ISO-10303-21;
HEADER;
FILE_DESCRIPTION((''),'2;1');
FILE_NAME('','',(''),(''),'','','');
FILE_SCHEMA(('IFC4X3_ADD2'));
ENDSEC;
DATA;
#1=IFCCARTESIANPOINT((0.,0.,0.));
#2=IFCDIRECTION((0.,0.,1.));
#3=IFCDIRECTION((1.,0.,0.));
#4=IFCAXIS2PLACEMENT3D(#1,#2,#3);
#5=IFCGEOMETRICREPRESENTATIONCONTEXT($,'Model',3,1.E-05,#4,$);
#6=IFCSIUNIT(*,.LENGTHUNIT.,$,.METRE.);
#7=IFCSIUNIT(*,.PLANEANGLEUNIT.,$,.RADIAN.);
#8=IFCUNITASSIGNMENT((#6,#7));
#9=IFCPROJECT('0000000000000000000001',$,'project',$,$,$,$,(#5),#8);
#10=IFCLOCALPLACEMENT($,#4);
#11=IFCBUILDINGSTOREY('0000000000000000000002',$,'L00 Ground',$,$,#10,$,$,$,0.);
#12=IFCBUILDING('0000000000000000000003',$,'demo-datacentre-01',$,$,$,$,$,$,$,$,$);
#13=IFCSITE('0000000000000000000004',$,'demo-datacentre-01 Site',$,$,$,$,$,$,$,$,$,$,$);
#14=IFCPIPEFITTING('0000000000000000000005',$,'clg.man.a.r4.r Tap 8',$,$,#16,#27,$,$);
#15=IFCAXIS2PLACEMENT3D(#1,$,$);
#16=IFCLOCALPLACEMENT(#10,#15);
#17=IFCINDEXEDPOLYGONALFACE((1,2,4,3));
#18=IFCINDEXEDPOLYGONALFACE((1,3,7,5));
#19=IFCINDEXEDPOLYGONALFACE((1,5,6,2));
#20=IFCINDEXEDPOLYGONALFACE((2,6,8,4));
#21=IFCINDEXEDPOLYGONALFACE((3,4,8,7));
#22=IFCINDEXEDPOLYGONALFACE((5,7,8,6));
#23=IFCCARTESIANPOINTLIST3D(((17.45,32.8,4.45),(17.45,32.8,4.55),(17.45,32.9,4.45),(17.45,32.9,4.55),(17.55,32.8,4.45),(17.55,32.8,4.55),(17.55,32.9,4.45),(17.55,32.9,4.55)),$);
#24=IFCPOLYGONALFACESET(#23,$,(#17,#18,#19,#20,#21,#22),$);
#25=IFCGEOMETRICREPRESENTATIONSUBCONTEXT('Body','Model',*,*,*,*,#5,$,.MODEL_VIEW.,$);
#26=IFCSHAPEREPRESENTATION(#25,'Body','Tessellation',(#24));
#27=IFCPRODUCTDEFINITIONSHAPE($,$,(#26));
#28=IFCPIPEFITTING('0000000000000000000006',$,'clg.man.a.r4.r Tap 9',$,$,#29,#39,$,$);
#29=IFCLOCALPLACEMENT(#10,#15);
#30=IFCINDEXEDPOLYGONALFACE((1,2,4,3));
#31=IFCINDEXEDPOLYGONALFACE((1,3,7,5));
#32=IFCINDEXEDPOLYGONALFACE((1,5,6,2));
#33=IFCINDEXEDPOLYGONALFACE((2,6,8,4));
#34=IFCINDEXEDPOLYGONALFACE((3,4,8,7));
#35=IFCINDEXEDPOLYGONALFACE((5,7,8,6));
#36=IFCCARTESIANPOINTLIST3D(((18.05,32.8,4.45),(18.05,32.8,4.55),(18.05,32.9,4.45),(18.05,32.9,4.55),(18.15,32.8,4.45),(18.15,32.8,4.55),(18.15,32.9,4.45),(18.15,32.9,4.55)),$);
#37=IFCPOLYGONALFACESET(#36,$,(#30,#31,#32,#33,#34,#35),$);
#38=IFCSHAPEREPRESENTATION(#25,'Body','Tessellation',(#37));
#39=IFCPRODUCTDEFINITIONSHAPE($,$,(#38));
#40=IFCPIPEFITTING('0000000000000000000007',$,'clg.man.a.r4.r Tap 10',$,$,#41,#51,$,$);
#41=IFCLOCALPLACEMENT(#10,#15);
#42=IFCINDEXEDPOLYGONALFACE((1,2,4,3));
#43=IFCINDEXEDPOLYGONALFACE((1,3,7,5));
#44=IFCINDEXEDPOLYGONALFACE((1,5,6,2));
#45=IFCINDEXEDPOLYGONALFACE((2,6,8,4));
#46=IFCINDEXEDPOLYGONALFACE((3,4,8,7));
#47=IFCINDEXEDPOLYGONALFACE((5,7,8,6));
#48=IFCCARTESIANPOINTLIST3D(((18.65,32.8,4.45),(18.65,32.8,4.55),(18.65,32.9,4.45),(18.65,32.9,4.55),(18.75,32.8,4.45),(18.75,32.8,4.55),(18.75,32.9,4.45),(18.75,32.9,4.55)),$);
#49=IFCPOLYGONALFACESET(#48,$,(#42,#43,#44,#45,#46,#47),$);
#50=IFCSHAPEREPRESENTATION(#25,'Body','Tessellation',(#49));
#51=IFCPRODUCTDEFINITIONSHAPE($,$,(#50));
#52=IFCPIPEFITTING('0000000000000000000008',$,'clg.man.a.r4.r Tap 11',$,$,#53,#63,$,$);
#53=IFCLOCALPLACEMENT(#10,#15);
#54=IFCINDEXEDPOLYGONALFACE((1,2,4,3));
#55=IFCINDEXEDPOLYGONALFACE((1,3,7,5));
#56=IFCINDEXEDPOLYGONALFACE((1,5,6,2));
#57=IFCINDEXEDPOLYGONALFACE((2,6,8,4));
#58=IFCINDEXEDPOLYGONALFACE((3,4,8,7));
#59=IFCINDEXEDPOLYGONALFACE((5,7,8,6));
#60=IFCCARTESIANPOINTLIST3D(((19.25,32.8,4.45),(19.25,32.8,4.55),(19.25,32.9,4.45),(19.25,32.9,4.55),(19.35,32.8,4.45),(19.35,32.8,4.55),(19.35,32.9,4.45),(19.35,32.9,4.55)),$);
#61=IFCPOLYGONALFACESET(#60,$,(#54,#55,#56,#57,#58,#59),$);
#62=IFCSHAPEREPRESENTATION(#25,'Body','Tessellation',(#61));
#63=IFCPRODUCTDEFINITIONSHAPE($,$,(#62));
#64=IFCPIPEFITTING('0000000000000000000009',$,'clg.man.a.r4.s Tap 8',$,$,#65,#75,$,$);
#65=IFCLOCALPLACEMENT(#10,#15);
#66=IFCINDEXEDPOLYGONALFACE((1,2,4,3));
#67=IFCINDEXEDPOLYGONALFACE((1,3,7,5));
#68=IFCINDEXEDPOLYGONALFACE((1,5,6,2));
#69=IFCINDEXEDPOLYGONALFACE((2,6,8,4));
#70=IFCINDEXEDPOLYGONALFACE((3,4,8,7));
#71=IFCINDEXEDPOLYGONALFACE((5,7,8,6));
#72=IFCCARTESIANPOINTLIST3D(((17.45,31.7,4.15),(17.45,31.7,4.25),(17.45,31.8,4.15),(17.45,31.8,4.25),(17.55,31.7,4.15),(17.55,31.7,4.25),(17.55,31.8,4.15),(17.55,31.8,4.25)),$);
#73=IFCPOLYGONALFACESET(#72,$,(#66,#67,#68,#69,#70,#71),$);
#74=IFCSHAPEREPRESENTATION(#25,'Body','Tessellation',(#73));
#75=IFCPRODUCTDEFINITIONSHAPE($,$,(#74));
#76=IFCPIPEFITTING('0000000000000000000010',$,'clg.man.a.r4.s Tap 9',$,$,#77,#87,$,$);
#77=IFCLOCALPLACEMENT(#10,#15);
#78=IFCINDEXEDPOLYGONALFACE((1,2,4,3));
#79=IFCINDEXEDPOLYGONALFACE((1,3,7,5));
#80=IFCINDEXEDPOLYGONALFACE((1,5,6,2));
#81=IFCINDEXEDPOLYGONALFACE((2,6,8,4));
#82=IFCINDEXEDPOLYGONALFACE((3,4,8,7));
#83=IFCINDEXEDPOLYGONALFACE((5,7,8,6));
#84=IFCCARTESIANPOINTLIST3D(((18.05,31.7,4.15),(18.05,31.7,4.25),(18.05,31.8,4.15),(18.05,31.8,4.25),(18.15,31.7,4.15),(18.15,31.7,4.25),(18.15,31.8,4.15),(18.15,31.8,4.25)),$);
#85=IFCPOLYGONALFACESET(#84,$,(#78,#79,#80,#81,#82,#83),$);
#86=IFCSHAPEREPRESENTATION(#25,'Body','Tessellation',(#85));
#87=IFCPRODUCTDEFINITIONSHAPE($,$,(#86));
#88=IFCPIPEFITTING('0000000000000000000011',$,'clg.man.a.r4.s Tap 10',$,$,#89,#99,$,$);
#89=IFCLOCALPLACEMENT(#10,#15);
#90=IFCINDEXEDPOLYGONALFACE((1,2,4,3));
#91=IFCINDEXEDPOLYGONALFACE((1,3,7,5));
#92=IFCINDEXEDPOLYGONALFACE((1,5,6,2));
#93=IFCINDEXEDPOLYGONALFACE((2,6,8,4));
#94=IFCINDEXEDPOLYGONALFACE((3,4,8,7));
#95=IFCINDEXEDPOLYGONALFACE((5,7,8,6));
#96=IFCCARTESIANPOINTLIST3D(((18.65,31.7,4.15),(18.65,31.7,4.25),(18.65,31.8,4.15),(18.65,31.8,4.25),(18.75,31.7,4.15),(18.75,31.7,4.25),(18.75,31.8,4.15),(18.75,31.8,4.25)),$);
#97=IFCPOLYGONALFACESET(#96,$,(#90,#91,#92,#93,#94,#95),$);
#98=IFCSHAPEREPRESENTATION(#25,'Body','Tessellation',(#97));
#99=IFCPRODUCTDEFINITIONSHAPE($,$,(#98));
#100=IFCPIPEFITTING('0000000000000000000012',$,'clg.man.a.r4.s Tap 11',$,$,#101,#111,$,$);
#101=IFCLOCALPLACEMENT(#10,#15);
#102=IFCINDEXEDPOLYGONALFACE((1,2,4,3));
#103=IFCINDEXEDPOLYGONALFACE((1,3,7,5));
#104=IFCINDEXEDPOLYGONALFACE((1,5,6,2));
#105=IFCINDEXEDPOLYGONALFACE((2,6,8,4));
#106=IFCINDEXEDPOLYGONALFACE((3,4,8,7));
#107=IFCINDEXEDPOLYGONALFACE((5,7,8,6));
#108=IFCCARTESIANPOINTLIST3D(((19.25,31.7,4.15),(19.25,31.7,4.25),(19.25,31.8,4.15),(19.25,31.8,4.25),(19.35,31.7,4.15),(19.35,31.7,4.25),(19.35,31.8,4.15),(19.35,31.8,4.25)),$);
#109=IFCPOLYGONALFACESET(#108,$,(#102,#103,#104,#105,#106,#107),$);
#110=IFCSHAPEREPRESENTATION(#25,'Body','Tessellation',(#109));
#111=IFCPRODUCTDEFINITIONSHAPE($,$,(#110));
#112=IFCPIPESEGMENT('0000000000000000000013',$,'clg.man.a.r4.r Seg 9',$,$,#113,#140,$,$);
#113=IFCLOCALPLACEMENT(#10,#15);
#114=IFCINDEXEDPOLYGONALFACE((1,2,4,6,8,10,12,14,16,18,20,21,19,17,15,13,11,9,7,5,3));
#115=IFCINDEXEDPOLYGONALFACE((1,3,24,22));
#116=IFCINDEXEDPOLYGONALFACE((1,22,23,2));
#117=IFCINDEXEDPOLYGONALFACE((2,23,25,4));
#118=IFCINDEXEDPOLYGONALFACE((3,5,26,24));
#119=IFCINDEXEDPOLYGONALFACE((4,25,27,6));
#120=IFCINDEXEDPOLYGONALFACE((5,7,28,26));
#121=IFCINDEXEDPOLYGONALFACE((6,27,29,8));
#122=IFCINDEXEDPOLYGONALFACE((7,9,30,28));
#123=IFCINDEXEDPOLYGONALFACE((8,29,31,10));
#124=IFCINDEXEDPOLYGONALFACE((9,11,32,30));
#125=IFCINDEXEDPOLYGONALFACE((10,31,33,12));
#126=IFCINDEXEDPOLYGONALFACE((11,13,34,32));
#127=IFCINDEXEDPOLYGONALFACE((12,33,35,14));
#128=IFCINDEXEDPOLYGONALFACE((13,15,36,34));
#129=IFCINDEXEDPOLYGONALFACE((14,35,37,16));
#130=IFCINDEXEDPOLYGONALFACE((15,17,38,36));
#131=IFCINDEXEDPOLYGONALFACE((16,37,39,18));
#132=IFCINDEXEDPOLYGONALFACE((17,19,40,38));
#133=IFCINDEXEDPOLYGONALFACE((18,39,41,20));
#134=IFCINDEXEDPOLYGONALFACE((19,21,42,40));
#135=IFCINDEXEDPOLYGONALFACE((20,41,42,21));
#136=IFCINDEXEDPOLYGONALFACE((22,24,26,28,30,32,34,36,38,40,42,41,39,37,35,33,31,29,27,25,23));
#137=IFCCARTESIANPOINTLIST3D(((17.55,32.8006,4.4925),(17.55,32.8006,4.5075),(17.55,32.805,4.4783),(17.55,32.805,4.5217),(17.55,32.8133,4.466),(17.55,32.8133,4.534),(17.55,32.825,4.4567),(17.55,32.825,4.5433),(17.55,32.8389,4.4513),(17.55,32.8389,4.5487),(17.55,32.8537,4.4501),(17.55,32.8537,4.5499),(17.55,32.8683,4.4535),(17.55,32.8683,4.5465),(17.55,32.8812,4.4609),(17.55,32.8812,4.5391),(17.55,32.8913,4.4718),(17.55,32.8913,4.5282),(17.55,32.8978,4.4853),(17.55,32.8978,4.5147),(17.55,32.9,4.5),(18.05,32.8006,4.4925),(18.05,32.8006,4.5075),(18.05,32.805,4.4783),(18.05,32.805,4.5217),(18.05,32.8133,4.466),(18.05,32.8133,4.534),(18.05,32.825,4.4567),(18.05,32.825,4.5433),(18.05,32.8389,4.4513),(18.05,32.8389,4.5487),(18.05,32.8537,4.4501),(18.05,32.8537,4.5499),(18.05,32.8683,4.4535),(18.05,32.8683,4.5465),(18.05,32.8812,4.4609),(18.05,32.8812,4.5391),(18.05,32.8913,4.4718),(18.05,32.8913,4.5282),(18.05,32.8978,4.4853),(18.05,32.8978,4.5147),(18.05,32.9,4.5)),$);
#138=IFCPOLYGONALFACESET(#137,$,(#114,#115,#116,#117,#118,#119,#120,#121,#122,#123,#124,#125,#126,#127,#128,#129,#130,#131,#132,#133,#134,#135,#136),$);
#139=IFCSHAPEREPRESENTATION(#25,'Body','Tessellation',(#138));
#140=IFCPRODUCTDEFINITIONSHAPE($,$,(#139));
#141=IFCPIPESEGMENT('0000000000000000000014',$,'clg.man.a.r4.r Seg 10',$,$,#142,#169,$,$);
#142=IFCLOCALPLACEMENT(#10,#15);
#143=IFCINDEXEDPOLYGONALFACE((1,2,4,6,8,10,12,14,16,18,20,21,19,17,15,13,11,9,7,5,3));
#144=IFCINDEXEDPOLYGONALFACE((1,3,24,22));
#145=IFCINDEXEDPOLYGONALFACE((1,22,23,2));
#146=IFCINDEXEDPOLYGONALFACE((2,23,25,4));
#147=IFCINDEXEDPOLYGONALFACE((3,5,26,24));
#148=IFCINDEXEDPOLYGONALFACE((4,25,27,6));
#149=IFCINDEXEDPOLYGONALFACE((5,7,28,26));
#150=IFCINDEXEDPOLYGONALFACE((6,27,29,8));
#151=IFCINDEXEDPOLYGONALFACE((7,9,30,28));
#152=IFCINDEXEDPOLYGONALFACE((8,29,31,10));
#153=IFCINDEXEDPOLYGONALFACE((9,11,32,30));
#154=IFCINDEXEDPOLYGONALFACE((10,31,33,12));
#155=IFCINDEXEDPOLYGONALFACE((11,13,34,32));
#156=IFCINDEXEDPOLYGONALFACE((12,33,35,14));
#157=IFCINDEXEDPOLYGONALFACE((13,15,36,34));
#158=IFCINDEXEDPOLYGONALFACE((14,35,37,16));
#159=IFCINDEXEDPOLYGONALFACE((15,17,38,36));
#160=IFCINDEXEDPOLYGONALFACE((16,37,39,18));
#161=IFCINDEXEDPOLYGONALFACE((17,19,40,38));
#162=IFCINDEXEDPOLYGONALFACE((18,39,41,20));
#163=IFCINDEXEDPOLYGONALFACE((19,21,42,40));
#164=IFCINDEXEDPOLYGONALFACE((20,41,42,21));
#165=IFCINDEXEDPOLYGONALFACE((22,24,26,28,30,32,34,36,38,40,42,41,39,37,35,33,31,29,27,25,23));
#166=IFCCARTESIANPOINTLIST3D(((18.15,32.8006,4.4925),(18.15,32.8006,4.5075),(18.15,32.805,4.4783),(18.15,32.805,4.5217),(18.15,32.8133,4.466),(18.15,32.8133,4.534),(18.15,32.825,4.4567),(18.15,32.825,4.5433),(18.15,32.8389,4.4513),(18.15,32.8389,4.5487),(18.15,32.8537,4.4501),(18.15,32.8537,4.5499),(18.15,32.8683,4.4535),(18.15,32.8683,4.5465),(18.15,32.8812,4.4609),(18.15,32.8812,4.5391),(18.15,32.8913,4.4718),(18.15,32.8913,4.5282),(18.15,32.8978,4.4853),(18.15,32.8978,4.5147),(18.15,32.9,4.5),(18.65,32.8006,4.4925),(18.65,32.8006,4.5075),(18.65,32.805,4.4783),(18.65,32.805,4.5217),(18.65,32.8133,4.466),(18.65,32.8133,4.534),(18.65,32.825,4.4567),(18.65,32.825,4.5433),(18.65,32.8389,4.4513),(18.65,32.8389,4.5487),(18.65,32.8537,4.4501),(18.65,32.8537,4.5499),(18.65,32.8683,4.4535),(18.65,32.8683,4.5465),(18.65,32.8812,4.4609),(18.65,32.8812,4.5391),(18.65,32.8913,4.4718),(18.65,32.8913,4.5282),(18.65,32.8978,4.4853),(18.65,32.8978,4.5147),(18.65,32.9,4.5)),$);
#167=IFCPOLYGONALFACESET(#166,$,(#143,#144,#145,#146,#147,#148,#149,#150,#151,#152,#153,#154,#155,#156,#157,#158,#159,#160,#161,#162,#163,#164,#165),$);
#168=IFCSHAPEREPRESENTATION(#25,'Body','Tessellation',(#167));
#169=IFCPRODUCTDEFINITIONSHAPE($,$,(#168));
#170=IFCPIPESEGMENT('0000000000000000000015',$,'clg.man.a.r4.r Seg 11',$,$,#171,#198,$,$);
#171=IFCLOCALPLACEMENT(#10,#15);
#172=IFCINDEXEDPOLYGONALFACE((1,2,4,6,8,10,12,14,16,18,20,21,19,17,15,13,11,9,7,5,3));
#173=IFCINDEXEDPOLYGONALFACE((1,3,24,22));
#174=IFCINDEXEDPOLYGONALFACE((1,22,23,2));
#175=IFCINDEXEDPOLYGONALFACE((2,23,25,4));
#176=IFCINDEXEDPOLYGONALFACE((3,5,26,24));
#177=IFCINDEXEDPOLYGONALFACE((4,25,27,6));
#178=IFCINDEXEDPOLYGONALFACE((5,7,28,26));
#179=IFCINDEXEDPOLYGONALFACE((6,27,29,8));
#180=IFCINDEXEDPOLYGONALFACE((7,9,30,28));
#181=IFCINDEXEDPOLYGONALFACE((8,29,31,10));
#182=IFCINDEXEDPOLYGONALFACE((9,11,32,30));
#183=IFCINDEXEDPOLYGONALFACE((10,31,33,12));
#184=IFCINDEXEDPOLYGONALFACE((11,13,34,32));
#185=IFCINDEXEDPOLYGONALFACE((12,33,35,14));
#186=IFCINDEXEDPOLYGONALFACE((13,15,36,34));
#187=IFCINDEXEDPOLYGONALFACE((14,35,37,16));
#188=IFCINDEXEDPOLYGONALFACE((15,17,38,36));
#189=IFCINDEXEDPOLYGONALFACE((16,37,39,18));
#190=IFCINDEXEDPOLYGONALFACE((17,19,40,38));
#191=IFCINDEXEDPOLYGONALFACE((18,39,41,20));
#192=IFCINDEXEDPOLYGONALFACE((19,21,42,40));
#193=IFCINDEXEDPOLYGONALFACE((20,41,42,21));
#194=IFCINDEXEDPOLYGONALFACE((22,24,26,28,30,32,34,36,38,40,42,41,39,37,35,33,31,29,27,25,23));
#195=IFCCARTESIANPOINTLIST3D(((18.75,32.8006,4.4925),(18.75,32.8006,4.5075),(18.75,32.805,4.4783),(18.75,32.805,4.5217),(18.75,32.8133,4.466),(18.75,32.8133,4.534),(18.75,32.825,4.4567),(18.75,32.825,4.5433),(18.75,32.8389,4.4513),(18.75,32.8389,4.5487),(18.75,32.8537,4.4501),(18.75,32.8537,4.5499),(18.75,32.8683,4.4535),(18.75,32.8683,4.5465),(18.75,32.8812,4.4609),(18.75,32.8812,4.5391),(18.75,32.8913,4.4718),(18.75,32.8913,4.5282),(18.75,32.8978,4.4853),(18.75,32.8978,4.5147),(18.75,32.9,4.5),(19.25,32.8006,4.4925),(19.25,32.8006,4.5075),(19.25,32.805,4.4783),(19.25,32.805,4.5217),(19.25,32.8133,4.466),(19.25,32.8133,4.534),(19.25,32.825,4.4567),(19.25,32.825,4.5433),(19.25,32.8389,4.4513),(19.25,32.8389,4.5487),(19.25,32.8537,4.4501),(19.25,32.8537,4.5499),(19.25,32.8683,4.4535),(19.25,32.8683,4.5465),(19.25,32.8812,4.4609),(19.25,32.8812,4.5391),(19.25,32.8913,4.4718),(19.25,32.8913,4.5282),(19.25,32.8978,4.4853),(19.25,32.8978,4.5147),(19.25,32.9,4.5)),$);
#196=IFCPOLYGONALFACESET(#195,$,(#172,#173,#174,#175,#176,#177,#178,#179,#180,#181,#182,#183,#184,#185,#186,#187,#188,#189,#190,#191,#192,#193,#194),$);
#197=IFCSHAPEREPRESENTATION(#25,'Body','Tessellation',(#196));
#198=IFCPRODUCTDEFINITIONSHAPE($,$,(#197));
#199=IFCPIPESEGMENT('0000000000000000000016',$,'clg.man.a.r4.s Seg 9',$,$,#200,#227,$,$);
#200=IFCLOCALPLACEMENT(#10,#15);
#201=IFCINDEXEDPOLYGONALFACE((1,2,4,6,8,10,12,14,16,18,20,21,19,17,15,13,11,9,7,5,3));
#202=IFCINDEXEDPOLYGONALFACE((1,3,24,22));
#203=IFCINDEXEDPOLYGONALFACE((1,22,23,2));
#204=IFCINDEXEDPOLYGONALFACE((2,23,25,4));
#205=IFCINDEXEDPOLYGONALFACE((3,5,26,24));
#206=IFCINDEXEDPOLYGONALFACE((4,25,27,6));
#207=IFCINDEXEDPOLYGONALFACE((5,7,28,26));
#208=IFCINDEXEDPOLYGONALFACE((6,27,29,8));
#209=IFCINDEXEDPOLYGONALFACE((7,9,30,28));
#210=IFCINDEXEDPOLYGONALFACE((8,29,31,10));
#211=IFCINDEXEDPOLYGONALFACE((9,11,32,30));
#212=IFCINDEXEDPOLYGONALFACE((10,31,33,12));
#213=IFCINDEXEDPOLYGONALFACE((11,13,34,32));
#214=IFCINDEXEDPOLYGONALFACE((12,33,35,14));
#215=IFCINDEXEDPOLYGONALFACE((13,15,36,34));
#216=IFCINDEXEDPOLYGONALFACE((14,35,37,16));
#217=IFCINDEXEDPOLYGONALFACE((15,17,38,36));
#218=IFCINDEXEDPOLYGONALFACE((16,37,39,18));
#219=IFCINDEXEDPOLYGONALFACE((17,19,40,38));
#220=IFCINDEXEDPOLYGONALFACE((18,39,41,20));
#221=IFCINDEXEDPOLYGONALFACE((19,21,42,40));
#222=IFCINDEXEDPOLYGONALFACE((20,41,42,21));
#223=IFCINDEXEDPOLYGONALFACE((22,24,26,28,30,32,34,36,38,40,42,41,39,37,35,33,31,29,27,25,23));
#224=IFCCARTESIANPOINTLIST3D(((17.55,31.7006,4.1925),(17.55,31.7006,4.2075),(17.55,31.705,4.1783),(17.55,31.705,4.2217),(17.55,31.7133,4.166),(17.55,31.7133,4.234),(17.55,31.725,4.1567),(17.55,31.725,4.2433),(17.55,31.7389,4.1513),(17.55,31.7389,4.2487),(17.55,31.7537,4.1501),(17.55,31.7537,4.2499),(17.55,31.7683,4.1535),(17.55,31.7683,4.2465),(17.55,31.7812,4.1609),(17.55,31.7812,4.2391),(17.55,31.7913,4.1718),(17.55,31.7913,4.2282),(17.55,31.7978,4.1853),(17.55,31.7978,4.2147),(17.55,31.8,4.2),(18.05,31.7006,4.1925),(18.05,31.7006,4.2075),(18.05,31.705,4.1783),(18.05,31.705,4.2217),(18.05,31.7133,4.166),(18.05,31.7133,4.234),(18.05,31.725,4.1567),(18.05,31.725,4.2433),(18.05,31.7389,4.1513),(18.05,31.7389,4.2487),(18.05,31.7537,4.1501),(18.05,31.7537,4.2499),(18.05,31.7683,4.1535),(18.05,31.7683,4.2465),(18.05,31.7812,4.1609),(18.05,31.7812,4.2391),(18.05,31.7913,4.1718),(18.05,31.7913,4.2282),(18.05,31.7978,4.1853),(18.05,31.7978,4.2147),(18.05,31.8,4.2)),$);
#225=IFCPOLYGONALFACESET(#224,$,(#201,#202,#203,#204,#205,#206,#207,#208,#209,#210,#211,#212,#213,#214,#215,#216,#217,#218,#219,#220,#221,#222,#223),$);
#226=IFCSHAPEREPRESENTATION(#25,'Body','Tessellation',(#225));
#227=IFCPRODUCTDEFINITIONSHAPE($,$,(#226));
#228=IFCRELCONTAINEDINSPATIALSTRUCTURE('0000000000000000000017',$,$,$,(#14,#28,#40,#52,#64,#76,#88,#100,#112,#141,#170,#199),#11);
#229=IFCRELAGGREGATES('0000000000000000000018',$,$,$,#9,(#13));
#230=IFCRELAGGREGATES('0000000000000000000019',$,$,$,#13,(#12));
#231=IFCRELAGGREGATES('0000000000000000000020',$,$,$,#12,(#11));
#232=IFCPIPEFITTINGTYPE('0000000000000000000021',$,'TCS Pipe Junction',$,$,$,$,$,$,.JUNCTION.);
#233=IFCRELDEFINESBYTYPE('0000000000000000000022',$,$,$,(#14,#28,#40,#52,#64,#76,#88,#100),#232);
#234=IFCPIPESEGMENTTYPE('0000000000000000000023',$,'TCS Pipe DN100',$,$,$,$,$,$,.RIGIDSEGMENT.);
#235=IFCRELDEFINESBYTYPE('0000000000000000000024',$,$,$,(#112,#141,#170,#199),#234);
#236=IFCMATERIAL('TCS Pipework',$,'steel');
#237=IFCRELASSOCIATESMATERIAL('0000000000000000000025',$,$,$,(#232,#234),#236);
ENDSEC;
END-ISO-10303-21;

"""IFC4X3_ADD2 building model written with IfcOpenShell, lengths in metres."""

from ifc_helpers import new_model, si_unit, frame, origin_with_axes, place, context, subcontext, project, spatial, rectangle, circle, extrude, material, type_object, element, save


model = new_model("IFC4X3_ADD2")

# Units and contexts
model_context = context("Model", 3, precision=1e-05, world=origin_with_axes())
body_context = subcontext(model_context, "Body", "Model", "MODEL_VIEW")
ifc_project = project(units=[si_unit("LENGTHUNIT", "METRE"), si_unit("PLANEANGLEUNIT", "RADIAN")], contexts=[model_context])

# Site, building, storey
site = spatial("IfcSite", under=ifc_project, Name="demo-datacentre-01 Site")
building = spatial("IfcBuilding", under=site, Name="demo-datacentre-01")
storey_placement = place(None, origin_with_axes())
storey = spatial("IfcBuildingStorey", under=building, at=storey_placement, Name="L00 Ground", Elevation=0.0)

# Pipe fittings
ifc_material = material(Name="TCS Pipework", Category="steel")
pipe_fitting_type = type_object("IfcPipeFittingType", Name="TCS Pipe Junction", PredefinedType="JUNCTION", material=ifc_material)
for number, where, z_axis, x_axis, name in (
    (1, (17.5, 32.85, 4.45), (0.0, 0.0, 1.0), (1.0, 0.0, 0.0), "clg.man.a.r4.r Tap 8"),
    (2, (18.1, 32.85, 4.45), (0.0, 0.0, 1.0), (1.0, 0.0, 0.0), "clg.man.a.r4.r Tap 9"),
    (3, (18.7, 32.85, 4.45), (0.0, 0.0, 1.0), (1.0, 0.0, 0.0), "clg.man.a.r4.r Tap 10"),
    (4, (19.3, 32.85, 4.45), (0.0, 0.0, 1.0), (1.0, 0.0, 0.0), "clg.man.a.r4.r Tap 11"),
    (5, (17.5, 31.75, 4.15), (0.0, 0.0, 1.0), (1.0, 0.0, 0.0), "clg.man.a.r4.s Tap 8"),
    (6, (18.1, 31.75, 4.15), (0.0, 0.0, 1.0), (1.0, 0.0, 0.0), "clg.man.a.r4.s Tap 9"),
    (7, (18.7, 31.75, 4.15), (0.0, 0.0, 1.0), (1.0, 0.0, 0.0), "clg.man.a.r4.s Tap 10"),
    (8, (19.3, 31.75, 4.15), (0.0, 0.0, 1.0), (1.0, 0.0, 0.0), "clg.man.a.r4.s Tap 11"),
):
    element("IfcPipeFitting", number, at=place(storey_placement, frame(where, z_axis=z_axis, x_axis=x_axis)), inside=storey, type_object=pipe_fitting_type, Name=name, context=body_context, shape_type="SweptSolid", body=[
        extrude(rectangle(XDim=0.1, YDim=0.1), origin_with_axes(), (0.0, 0.0, 1.0), 0.1),
    ])

# Pipe segments
pipe_segment_type_1 = type_object("IfcPipeSegmentType", Name="TCS Pipe DN100", PredefinedType="RIGIDSEGMENT", material=ifc_material)
pipe_segment_1_placement = place(storey_placement, frame((17.55, 32.85, 4.5), z_axis=(1.0, 0.0, 0.0), x_axis=(0.0, 1.0, 0.0)))
element("IfcPipeSegment", 9, at=pipe_segment_1_placement, inside=storey, type_object=pipe_segment_type_1, Name="clg.man.a.r4.r Seg 9", context=body_context, shape_type="SweptSolid", body=[
    extrude(circle(Radius=0.05), origin_with_axes(), (0.0, 0.0, 1.0), 0.5),
])
pipe_segment_2_placement = place(storey_placement, frame((18.15, 32.85, 4.5), z_axis=(1.0, 0.0, 0.0), x_axis=(0.0, 1.0, 0.0)))
element("IfcPipeSegment", 10, at=pipe_segment_2_placement, inside=storey, type_object=pipe_segment_type_1, Name="clg.man.a.r4.r Seg 10", context=body_context, shape_type="SweptSolid", body=[
    extrude(circle(Radius=0.05), origin_with_axes(), (0.0, 0.0, 1.0), 0.5),
])
for number, where, z_axis, x_axis, name in (
    (11, (18.75, 32.85, 4.5), (1.0, 0.0, 0.0), (0.0, 1.0, 0.0), "clg.man.a.r4.r Seg 11"),
    (12, (17.55, 31.75, 4.2), (1.0, 0.0, 0.0), (0.0, 1.0, 0.0), "clg.man.a.r4.s Seg 9"),
):
    element("IfcPipeSegment", number, at=place(storey_placement, frame(where, z_axis=z_axis, x_axis=x_axis)), inside=storey, type_object=pipe_segment_type_1, Name=name, context=body_context, shape_type="SweptSolid", body=[
        extrude(circle(Radius=0.05), origin_with_axes(), (0.0, 0.0, 1.0), 0.5),
    ])

save(model, "model.ifc")
